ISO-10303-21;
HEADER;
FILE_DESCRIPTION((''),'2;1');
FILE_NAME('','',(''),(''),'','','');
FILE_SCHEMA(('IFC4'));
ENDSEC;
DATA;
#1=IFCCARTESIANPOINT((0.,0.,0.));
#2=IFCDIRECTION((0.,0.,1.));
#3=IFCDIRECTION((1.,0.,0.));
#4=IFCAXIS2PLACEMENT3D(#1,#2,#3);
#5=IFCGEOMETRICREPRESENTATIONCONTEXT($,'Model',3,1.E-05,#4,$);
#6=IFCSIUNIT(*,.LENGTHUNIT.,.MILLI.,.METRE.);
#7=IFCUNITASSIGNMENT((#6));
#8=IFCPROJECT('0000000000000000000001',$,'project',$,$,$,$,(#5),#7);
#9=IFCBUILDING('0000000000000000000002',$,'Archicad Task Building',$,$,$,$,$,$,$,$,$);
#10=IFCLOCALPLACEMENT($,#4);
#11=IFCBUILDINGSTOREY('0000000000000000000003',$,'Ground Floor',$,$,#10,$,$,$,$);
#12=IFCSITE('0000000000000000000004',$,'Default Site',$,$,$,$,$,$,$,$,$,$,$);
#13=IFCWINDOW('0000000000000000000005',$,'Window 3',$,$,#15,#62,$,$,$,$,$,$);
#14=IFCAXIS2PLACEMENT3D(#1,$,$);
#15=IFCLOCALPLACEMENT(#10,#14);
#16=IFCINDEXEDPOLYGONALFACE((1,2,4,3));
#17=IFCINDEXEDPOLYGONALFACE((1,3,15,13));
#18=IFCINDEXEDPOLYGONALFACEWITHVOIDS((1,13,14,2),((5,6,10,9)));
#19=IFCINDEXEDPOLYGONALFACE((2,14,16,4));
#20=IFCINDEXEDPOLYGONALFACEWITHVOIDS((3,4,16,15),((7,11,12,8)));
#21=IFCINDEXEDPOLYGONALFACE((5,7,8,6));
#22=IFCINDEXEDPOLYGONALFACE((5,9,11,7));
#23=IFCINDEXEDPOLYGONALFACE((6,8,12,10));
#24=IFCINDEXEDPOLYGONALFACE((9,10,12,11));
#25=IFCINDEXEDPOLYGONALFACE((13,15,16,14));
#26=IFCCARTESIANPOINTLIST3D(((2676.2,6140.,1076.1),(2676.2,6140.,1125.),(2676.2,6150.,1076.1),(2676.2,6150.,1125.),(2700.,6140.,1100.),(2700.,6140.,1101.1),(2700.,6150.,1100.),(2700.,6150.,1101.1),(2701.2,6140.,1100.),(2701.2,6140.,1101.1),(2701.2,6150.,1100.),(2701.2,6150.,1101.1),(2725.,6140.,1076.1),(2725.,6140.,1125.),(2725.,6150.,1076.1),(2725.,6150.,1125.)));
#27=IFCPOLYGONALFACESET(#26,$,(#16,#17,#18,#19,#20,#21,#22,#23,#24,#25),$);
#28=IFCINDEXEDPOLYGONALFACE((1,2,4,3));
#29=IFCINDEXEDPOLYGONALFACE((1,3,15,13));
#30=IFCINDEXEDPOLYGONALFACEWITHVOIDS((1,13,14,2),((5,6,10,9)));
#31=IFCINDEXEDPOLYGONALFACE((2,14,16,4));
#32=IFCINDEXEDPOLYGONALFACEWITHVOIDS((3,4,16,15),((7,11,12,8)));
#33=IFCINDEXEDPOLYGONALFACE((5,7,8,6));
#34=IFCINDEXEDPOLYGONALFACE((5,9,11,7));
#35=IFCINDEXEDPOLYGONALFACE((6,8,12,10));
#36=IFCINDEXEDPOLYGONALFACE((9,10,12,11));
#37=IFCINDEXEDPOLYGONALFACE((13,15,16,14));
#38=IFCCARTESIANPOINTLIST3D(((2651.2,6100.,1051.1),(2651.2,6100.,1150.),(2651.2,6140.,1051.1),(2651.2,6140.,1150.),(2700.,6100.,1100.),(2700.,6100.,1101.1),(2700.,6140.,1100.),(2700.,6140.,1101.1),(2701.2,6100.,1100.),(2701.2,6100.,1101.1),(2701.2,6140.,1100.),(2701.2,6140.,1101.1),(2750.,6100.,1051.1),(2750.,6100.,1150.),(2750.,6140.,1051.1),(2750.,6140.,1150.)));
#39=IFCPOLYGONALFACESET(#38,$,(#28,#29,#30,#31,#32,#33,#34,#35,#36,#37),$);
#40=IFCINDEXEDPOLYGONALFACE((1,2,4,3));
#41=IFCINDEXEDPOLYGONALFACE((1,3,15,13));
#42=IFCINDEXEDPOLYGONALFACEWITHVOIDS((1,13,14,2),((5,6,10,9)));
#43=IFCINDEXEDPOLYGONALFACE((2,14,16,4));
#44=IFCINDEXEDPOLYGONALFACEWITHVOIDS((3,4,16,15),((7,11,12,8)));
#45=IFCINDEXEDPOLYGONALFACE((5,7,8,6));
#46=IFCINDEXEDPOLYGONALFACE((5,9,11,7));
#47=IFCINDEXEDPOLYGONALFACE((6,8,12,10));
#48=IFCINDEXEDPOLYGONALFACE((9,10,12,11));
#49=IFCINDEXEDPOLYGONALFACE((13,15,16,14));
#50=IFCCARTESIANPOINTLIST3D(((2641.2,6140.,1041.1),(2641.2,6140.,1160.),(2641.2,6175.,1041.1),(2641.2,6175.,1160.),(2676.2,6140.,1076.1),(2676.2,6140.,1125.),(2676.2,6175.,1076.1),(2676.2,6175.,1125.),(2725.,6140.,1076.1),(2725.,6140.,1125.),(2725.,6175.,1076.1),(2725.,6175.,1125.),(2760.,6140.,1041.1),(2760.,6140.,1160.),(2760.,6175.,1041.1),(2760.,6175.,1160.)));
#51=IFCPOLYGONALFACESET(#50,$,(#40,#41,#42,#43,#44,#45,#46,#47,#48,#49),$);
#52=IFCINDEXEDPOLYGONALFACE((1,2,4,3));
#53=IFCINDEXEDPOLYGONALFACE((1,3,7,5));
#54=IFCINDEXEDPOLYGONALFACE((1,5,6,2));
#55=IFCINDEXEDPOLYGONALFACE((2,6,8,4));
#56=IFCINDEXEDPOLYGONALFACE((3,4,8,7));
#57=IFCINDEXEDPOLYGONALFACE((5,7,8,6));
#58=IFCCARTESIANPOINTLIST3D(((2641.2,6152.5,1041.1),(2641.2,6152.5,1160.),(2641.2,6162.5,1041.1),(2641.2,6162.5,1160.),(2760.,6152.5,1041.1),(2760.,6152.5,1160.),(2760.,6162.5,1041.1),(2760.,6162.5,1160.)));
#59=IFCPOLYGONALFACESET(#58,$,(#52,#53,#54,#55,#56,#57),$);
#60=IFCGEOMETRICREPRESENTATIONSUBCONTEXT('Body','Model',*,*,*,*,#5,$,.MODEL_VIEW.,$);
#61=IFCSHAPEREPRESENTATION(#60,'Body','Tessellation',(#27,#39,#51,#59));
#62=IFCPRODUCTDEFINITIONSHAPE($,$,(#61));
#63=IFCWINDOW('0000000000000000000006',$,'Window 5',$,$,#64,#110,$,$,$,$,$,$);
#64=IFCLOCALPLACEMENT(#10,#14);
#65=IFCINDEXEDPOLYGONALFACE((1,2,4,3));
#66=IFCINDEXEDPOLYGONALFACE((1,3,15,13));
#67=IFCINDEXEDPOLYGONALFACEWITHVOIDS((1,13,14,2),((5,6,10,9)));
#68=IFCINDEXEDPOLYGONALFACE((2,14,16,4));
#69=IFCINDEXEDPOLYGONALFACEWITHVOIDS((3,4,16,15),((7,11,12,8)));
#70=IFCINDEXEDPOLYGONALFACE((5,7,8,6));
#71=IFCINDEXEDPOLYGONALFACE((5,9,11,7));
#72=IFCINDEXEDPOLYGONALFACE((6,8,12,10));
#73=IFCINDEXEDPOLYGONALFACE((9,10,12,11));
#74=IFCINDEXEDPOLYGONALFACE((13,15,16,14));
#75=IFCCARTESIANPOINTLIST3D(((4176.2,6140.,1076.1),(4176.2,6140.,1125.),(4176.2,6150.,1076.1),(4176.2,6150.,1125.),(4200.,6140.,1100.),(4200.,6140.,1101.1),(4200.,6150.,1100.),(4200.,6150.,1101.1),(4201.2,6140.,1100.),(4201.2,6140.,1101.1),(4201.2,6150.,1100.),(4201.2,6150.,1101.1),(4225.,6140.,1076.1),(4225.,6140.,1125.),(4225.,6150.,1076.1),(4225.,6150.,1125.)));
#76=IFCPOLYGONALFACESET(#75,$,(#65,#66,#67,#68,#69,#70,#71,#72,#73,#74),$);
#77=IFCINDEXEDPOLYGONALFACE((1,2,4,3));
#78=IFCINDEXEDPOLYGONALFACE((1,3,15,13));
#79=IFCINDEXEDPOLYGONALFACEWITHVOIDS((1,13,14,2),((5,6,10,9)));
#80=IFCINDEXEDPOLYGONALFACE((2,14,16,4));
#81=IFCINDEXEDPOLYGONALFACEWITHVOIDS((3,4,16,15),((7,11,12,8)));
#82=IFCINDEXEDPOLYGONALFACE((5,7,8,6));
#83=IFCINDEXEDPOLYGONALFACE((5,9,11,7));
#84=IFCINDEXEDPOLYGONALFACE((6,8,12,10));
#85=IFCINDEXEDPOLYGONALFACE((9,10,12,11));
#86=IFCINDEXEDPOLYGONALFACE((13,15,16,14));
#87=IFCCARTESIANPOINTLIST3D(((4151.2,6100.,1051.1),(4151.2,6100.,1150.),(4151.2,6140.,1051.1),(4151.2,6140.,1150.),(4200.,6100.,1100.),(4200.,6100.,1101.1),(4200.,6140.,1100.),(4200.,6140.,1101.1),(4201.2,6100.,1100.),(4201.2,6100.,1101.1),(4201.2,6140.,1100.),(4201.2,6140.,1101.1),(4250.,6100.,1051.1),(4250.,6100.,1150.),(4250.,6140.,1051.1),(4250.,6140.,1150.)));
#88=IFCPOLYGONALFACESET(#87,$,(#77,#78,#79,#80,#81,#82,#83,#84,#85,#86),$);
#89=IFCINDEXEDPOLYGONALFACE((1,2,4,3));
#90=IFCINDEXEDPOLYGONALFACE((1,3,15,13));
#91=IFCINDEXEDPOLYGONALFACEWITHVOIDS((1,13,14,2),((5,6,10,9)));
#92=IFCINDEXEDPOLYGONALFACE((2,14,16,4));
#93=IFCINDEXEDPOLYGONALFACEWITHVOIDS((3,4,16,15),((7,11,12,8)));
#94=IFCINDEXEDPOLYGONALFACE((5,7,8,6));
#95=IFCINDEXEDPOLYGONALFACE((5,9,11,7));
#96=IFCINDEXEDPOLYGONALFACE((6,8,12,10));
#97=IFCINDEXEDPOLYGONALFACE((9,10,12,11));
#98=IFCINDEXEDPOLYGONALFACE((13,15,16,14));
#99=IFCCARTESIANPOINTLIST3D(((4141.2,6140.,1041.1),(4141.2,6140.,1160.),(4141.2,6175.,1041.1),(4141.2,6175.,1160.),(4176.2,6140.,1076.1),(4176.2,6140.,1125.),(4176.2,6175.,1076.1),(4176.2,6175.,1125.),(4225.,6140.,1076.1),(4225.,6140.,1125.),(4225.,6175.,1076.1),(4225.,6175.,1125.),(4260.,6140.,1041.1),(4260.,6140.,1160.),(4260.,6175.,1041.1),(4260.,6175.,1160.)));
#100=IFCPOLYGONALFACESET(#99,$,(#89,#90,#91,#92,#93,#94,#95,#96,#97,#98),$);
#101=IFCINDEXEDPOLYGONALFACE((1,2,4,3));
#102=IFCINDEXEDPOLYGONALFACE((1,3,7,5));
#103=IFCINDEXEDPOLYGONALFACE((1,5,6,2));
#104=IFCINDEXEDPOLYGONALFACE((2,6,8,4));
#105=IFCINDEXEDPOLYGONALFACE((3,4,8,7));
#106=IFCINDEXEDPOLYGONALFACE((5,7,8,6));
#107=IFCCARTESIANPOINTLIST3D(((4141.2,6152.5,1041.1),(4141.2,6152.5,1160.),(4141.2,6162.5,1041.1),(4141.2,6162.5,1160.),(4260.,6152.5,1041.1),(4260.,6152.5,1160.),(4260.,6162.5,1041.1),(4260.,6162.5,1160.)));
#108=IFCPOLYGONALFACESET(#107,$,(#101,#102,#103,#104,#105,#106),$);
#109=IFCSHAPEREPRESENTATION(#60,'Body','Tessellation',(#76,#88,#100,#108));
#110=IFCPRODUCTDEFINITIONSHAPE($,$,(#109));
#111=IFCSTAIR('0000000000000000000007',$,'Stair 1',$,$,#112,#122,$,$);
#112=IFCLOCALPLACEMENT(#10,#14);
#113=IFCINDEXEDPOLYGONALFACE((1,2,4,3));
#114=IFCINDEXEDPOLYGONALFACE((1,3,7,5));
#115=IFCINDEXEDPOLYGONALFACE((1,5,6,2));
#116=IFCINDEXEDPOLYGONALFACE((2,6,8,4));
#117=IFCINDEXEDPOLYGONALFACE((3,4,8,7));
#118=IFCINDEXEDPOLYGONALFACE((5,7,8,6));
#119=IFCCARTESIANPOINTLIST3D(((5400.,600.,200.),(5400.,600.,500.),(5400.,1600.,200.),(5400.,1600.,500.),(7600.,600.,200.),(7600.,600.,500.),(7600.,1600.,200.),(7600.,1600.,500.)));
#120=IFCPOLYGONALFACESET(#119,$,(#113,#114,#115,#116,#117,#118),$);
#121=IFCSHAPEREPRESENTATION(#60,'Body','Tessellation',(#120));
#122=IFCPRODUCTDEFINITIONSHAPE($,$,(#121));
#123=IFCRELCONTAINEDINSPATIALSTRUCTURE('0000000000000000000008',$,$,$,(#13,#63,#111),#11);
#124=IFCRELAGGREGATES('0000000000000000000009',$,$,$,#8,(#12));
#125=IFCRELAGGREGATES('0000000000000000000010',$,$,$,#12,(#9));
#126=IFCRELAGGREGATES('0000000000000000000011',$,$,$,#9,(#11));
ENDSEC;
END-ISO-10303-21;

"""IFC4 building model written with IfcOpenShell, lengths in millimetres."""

from ifc_helpers import new_model, si_unit, frame, origin_with_axes, place, context, subcontext, project, spatial, line, indexed_curve, outline, extrude, element, save


model = new_model("IFC4")

# Units and contexts
model_context = context("Model", 3, precision=1e-05, world=origin_with_axes())
body_context = subcontext(model_context, "Body", "Model", "MODEL_VIEW")
ifc_project = project(units=[si_unit("LENGTHUNIT", "METRE", prefix="MILLI")], contexts=[model_context])

# Site, building, storey
site = spatial("IfcSite", under=ifc_project, Name="Default Site")
building = spatial("IfcBuilding", under=site, Name="Archicad Task Building")
storey_placement = place(None, origin_with_axes())
storey = spatial("IfcBuildingStorey", under=building, at=storey_placement, Name="Ground Floor")

# Windows
for number, where, z_axis, x_axis, name in (
    (1, (2700.0, 6050.0, 1100.0), (0.0, 0.0, 1.0), (1.0, 0.0, 0.0), "Window 3"),
    (2, (4200.0, 6050.0, 1100.0), (0.0, 0.0, 1.0), (1.0, 0.0, 0.0), "Window 5"),
):
    element("IfcWindow", number, at=place(storey_placement, frame(where, z_axis=z_axis, x_axis=x_axis)), inside=storey, Name=name, context=body_context, shape_type="SweptSolid", body=[
        extrude(outline(indexed_curve([(0.0, 0.0), (1.2, 0.0), (1.2, 1.1), (0.0, 1.1)], segments=[line(1, 2, 3, 4, 1)]), holes=[indexed_curve([(25.0, 25.0), (-23.8, 25.0), (-23.8, -23.9), (25.0, -23.9)], segments=[line(1, 2, 3, 4, 1)])]), frame((0.0, 90.0, 0.0), z_axis=(0.0, -1.0, 0.0), x_axis=(1.0, 0.0, 0.0)), (0.0, 0.0, -1.0), 10.0),
        extrude(outline(indexed_curve([(0.0, 0.0), (1.2, 0.0), (1.2, 1.1), (0.0, 1.1)], segments=[line(1, 2, 3, 4, 1)]), holes=[indexed_curve([(50.0, 50.0), (-48.8, 50.0), (-48.8, -48.9), (50.0, -48.9)], segments=[line(1, 2, 3, 4, 1)])]), frame((0.0, 50.0, 0.0), z_axis=(0.0, -1.0, 0.0), x_axis=(1.0, 0.0, 0.0)), (0.0, 0.0, -1.0), 40.0),
        extrude(outline(indexed_curve([(0.0, 0.0), (-48.8, 0.0), (-48.8, -48.9), (0.0, -48.9)], segments=[line(1, 2, 3, 4, 1)]), holes=[indexed_curve([(35.0, 35.0), (-83.8, 35.0), (-83.8, -83.9), (35.0, -83.9)], segments=[line(1, 2, 3, 4, 1)])]), frame((25.0, 90.0, 25.0), z_axis=(0.0, -1.0, 0.0), x_axis=(1.0, 0.0, 0.0)), (0.0, 0.0, -1.0), 35.0),
        extrude(outline(indexed_curve([(35.0, 35.0), (-83.8, 35.0), (-83.8, -83.9), (35.0, -83.9)], segments=[line(1, 2, 3, 4, 1)])), frame((25.0, 102.5, 25.0), z_axis=(0.0, -1.0, 0.0), x_axis=(1.0, 0.0, 0.0)), (0.0, 0.0, -1.0), 10.0),
    ])

# Stair
stair_placement = place(storey_placement, frame((5400.0, 600.0, 200.0), z_axis=(0.0, 0.0, 1.0), x_axis=(1.0, 0.0, 0.0)))
element("IfcStair", 3, at=stair_placement, inside=storey, Name="Stair 1", context=body_context, shape_type="SweptSolid", body=[
    extrude(outline(indexed_curve([(0.0, 0.0), (2200.0, 0.0), (2200.0, 1000.0), (0.0, 1000.0), (0.0, 0.0)])), None, (0.0, 0.0, 1.0), 300.0),
])

save(model, "model.ifc")
